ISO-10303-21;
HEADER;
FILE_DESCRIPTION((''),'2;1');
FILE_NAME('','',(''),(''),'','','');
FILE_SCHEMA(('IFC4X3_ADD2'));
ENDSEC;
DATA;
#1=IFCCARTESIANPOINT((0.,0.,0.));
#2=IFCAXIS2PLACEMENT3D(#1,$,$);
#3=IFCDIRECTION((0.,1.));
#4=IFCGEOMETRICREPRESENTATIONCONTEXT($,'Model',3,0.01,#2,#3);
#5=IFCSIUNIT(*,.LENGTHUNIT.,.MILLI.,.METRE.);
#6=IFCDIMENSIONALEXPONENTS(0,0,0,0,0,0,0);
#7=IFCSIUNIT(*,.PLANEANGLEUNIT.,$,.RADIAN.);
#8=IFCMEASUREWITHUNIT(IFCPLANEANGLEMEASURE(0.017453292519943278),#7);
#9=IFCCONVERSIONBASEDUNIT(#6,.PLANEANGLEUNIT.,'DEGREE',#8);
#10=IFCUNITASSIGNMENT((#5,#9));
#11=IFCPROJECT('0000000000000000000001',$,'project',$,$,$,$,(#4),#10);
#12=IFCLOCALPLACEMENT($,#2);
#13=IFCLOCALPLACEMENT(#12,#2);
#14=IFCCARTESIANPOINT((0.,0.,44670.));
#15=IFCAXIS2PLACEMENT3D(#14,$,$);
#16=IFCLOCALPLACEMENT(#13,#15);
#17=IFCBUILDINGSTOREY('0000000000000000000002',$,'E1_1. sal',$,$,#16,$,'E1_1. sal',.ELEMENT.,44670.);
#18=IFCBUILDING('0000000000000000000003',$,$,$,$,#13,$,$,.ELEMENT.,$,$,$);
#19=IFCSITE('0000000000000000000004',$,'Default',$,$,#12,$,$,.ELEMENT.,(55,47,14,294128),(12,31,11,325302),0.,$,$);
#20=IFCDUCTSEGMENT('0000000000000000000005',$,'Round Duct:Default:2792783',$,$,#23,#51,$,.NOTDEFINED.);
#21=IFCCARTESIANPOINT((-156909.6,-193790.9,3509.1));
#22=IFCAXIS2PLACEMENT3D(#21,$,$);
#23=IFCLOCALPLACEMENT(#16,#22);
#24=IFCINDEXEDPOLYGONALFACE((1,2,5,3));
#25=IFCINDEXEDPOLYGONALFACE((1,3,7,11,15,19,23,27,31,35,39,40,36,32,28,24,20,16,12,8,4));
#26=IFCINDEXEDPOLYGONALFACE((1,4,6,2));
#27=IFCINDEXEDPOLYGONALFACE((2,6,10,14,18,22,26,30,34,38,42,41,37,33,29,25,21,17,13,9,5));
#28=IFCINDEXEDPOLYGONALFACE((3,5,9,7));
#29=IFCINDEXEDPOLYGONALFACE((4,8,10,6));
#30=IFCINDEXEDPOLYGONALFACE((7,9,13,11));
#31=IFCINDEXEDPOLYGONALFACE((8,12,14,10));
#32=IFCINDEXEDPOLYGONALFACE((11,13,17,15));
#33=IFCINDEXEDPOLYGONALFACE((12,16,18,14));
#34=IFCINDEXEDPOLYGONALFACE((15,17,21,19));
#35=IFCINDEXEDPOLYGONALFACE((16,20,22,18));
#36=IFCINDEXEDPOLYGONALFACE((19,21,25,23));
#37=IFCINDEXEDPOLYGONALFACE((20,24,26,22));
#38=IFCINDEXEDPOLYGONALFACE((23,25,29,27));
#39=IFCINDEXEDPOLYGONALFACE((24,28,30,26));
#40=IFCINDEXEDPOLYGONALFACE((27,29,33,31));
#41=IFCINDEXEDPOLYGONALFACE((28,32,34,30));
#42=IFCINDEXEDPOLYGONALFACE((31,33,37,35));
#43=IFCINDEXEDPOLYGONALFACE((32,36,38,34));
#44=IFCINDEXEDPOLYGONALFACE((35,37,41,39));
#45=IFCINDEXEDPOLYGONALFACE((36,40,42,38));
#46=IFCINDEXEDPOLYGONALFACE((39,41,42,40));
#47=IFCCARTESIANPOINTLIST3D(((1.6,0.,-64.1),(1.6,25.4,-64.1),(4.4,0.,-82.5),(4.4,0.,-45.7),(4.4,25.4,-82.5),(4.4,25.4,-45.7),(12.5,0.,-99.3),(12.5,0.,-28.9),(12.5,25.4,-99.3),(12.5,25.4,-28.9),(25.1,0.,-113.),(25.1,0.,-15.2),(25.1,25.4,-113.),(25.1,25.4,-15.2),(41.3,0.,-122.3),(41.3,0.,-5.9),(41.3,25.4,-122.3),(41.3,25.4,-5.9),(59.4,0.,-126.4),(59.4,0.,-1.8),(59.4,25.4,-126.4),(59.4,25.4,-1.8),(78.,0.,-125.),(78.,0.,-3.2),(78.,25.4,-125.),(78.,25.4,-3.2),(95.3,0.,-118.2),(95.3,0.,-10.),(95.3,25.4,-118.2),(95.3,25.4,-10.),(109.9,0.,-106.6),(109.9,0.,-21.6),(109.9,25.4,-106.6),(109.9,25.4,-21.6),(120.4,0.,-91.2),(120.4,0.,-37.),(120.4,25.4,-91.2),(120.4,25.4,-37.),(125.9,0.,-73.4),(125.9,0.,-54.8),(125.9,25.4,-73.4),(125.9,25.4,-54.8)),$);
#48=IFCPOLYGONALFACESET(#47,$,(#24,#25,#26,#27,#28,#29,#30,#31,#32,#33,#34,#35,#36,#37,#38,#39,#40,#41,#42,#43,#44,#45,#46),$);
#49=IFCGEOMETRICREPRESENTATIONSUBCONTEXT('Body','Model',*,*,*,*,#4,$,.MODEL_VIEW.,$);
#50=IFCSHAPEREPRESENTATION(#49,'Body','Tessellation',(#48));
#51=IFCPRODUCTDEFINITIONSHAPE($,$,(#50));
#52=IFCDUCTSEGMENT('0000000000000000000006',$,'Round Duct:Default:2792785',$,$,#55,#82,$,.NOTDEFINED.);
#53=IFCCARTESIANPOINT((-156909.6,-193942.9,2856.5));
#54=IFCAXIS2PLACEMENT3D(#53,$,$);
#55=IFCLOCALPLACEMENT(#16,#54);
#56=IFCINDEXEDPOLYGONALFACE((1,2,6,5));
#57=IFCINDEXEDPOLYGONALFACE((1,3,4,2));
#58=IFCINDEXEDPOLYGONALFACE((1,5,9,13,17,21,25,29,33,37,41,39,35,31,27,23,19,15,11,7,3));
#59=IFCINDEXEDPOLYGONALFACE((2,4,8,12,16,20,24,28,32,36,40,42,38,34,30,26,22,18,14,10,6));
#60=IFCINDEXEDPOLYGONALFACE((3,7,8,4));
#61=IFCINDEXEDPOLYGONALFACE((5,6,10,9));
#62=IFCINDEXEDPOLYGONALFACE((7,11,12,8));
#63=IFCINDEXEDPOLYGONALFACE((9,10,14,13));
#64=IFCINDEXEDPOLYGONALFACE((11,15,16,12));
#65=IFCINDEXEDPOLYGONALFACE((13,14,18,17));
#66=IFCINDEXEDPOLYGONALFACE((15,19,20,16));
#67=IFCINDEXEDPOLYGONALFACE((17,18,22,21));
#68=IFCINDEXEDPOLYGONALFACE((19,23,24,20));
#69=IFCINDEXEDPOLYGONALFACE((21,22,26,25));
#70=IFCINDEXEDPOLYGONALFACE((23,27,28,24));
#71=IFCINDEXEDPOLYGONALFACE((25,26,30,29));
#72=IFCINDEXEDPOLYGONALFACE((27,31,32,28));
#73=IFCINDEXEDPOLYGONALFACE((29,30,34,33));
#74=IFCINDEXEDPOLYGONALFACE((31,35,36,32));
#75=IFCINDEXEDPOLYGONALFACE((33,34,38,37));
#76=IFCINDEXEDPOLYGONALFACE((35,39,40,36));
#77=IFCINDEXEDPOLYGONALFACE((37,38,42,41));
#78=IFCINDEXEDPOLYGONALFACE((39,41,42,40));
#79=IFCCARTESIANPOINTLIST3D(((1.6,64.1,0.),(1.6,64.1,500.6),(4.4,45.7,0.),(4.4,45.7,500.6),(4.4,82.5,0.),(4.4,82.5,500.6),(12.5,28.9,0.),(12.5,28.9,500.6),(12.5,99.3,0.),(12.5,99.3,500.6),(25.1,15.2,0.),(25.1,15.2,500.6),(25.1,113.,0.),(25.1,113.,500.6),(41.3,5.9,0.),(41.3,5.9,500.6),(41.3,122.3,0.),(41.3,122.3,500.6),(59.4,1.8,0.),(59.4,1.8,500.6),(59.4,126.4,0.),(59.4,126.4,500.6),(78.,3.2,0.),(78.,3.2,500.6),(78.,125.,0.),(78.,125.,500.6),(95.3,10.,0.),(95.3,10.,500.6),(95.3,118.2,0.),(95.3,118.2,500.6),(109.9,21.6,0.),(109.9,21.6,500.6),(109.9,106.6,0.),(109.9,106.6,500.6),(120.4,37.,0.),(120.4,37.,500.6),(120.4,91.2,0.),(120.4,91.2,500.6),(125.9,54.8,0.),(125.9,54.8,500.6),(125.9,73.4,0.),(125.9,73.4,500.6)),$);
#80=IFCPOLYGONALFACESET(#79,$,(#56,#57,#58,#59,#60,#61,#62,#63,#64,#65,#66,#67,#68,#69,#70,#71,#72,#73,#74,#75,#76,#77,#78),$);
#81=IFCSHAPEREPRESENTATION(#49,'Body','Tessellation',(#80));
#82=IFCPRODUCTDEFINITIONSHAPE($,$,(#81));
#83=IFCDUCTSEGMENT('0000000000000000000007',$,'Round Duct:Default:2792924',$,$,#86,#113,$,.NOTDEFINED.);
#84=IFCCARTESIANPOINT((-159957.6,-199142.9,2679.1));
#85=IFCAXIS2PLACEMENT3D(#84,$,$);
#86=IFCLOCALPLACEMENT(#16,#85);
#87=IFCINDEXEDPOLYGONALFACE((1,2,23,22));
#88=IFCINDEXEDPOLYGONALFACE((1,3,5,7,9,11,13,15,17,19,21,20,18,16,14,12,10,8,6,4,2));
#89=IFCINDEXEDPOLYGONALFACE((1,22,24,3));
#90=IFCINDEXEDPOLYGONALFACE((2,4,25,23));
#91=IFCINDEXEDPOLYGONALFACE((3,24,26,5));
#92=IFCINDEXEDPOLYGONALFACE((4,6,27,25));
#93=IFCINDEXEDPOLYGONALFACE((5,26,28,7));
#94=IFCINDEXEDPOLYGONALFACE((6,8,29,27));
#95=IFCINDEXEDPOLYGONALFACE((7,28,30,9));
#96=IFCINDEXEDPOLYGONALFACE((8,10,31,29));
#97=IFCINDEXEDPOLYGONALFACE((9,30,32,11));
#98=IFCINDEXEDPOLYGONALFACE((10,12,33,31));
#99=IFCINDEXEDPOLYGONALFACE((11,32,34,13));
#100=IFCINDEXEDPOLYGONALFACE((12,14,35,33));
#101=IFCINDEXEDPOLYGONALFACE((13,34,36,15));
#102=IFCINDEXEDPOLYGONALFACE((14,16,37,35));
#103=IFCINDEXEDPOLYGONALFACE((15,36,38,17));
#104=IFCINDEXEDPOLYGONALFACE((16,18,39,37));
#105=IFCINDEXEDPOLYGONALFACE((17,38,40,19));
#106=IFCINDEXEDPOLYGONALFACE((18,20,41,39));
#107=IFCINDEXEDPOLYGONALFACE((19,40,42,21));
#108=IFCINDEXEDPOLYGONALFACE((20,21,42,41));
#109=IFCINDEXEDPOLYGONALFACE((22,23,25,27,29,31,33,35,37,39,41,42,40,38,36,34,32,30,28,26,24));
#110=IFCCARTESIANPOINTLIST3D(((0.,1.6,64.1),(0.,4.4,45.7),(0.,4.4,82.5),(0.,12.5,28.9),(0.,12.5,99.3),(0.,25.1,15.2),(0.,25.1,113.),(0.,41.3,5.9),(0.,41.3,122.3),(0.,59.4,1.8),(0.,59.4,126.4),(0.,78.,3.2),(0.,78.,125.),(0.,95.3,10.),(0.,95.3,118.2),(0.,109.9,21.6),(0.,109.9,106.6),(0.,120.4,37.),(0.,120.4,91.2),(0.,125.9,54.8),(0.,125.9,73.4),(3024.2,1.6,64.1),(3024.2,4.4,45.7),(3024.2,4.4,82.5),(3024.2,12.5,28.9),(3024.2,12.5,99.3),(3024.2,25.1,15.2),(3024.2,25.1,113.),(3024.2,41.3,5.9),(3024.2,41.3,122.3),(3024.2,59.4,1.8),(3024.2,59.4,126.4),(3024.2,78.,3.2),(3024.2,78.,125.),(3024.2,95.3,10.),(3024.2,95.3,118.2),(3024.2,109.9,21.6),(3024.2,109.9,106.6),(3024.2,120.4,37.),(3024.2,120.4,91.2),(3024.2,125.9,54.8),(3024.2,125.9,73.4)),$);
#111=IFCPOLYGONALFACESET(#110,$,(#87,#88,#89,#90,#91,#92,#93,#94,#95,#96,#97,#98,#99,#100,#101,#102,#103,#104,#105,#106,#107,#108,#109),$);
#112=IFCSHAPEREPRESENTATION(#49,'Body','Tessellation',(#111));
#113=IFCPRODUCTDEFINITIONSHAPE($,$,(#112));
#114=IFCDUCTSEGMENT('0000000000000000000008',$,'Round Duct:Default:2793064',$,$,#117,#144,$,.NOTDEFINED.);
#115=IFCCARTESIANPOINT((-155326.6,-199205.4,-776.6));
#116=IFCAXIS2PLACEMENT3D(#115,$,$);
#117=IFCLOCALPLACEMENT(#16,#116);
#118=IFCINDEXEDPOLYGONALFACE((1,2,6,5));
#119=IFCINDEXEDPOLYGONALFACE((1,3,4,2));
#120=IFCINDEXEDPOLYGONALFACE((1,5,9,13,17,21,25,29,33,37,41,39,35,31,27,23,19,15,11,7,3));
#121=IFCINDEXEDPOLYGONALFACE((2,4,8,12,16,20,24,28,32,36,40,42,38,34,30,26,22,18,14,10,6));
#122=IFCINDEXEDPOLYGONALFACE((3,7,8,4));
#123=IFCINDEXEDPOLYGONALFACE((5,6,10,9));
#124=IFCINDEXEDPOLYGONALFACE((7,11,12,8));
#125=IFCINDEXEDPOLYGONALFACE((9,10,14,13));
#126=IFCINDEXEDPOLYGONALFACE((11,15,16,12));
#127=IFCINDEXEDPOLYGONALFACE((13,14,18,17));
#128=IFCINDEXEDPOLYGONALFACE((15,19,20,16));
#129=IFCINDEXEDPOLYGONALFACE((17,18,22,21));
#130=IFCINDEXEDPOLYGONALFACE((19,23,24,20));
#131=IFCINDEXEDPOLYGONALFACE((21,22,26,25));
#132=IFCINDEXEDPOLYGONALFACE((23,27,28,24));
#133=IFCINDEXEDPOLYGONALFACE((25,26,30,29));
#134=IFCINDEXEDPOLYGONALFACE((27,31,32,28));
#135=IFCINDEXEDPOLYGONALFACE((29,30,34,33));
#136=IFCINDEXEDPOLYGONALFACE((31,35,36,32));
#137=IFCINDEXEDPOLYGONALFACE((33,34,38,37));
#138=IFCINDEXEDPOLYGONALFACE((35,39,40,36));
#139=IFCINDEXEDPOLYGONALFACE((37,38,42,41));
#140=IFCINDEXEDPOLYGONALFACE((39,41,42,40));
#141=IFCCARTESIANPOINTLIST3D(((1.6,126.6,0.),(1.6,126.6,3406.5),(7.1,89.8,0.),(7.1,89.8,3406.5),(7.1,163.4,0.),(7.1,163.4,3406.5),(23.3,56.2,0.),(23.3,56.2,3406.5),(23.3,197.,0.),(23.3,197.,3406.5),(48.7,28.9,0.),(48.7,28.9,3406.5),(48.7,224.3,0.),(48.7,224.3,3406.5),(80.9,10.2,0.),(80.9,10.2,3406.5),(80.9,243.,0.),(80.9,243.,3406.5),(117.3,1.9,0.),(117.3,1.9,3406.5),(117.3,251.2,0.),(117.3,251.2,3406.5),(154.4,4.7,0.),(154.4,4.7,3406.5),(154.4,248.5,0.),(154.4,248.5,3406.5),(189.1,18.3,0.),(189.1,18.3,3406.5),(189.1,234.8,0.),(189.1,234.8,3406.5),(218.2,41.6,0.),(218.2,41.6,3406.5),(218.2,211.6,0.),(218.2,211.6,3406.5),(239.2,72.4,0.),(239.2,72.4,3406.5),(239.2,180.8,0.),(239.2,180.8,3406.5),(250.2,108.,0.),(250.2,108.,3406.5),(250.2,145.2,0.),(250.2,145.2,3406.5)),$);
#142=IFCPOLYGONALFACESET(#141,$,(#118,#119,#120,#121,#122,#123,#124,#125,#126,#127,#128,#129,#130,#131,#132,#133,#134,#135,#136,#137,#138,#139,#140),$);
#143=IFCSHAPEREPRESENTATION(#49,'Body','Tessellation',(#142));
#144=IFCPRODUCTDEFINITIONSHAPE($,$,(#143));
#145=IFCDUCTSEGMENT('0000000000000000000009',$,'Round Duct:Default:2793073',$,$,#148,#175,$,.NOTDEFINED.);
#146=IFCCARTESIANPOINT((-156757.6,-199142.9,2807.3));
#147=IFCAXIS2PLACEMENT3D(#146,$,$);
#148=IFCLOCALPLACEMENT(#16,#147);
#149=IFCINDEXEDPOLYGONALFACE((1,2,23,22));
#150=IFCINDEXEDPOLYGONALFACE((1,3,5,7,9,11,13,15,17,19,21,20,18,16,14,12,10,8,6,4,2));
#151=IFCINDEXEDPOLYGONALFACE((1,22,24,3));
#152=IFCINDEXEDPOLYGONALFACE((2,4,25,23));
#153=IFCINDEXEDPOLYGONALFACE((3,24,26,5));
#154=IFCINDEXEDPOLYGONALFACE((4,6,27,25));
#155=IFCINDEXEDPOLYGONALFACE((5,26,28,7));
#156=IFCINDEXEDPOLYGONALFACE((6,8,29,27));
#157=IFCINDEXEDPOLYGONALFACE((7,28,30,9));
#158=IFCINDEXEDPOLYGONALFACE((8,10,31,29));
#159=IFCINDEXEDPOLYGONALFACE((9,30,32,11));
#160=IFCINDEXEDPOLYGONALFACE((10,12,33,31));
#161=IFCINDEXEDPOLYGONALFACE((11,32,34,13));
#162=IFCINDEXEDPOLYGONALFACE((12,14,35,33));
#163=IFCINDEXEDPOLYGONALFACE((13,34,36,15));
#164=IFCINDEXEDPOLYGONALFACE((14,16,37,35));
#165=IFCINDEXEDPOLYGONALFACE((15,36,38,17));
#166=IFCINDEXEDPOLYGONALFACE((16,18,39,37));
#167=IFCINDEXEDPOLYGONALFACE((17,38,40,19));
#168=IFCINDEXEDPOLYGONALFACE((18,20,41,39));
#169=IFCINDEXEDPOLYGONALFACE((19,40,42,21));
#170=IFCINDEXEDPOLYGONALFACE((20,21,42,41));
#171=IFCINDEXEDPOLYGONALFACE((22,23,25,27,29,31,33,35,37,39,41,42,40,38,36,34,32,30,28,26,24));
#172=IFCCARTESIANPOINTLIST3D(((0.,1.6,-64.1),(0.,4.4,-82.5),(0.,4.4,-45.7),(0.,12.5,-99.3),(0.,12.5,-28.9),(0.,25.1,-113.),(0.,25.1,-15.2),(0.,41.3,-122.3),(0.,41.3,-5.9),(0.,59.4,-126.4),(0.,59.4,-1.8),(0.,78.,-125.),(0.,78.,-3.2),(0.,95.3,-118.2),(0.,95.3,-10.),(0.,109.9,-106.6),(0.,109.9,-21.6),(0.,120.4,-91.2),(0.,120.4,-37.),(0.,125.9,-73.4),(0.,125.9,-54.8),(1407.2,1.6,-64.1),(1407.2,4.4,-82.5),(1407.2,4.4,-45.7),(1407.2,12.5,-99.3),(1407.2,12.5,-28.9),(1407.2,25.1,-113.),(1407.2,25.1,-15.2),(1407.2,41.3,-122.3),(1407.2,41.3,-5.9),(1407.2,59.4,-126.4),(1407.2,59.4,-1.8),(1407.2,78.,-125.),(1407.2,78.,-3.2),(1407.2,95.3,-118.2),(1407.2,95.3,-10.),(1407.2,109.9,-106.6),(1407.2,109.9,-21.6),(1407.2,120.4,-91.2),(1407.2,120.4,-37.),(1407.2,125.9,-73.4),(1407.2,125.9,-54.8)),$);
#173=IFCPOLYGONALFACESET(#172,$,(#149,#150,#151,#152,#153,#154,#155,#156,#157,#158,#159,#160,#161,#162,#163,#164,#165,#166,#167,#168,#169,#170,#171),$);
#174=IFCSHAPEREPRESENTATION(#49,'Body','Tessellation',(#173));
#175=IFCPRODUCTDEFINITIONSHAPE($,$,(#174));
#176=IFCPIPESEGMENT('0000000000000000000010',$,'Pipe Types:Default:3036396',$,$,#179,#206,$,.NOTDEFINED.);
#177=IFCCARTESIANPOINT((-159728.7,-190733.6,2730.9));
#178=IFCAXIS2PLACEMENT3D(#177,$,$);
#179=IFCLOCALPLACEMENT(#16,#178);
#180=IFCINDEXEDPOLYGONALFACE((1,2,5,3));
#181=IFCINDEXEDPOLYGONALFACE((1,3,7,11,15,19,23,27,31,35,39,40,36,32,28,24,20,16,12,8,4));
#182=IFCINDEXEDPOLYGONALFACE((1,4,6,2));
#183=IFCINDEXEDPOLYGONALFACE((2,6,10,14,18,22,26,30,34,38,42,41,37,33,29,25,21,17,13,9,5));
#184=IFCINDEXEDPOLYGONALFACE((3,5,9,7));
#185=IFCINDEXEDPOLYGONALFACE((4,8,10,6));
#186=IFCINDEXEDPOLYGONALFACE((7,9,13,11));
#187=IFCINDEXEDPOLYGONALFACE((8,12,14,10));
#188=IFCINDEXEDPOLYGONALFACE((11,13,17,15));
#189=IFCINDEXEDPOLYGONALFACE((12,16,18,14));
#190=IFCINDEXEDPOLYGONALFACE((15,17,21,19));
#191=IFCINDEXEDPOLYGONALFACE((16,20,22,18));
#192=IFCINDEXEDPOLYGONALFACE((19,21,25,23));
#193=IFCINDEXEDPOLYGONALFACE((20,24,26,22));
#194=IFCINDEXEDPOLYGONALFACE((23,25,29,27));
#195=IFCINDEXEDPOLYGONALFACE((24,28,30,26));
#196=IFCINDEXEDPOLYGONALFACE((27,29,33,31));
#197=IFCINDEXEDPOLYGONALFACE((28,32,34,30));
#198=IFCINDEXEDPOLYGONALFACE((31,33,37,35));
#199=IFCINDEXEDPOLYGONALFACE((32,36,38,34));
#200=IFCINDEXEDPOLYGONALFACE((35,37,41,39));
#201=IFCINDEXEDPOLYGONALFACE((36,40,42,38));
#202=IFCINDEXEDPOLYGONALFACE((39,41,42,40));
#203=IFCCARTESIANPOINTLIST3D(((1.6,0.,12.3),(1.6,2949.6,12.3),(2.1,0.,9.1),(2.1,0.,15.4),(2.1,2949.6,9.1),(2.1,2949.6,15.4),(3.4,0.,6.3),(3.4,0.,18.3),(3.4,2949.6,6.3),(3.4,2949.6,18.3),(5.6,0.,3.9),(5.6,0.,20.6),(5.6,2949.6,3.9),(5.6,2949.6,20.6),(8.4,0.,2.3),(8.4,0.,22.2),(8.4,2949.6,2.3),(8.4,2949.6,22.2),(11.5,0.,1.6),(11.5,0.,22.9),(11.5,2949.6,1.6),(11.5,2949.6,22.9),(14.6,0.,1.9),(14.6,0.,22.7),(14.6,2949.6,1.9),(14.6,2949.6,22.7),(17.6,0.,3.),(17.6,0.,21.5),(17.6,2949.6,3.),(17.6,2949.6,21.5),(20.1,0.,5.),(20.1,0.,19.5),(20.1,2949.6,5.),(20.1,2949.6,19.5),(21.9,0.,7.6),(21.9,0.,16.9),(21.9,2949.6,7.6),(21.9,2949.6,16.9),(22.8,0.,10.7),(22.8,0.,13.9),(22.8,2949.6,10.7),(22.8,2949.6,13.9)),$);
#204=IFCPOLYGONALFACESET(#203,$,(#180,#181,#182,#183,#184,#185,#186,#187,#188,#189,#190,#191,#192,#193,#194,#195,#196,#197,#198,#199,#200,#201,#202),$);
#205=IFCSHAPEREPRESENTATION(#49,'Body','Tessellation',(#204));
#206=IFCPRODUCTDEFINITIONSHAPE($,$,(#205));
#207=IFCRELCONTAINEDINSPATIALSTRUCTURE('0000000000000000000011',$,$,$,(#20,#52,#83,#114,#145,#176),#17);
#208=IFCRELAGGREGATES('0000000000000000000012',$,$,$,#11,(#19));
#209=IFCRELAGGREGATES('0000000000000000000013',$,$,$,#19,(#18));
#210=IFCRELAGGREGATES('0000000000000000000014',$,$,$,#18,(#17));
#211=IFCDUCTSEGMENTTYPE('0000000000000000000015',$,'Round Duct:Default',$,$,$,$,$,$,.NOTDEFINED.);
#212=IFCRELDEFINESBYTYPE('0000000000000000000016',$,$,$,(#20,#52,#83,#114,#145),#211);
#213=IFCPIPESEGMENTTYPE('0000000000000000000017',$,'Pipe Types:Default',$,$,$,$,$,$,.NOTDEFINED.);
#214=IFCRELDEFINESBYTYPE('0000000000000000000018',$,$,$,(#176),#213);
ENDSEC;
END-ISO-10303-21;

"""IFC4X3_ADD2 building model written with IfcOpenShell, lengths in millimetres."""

from ifc_helpers import new_model, entity, si_unit, converted_unit, direction, frame, origin, origin_2d_with_axis, place, context, subcontext, project, spatial, circle, extrude, type_object, element, save


model = new_model("IFC4X3_ADD2")

# Units and contexts
model_context = context("Model", 3, precision=0.01, world=origin(), true_north=direction((0.0, 1.0)))
body_context = subcontext(model_context, "Body", "Model", "MODEL_VIEW")
ifc_project = project(units=[si_unit("LENGTHUNIT", "METRE", prefix="MILLI"), converted_unit("PLANEANGLEUNIT", "DEGREE", entity("IfcPlaneAngleMeasure", 0.017453292519943278), si_unit("PLANEANGLEUNIT", "RADIAN"), dimensions=[0, 0, 0, 0, 0, 0, 0])], contexts=[model_context])

# Site, building, storey
site_placement = place(None, origin())
site = spatial("IfcSite", under=ifc_project, at=site_placement, Name="Default", CompositionType="ELEMENT", RefLatitude=(55, 47, 14, 294128), RefLongitude=(12, 31, 11, 325302), RefElevation=0.0)
building_placement = place(site_placement, origin())
building = spatial("IfcBuilding", under=site, at=building_placement, CompositionType="ELEMENT")
storey_placement = place(building_placement, frame((0.0, 0.0, 44670.0)))
storey = spatial("IfcBuildingStorey", under=building, at=storey_placement, Name="E1_1. sal", LongName="E1_1. sal", CompositionType="ELEMENT", Elevation=44670.0)

# Duct segments
duct_segment_type = type_object("IfcDuctSegmentType", Name="Round Duct:Default", PredefinedType="NOTDEFINED")
duct_segment_1_placement = place(storey_placement, frame((-156909.6, -193790.9, 3509.1)))
element("IfcDuctSegment", 1, at=duct_segment_1_placement, inside=storey, type_object=duct_segment_type, Name="Round Duct:Default:2792783", PredefinedType="NOTDEFINED", context=body_context, shape_type="SweptSolid", body=[
    extrude(circle(Radius=62.5, at=origin_2d_with_axis()), frame((64.1, 0.0, -64.1), z_axis=(0.0, 1.0, 0.0), x_axis=(-1.0, 0.0, 0.0)), (0.0, 0.0, 1.0), 25.4),
])
duct_segment_2_placement = place(storey_placement, frame((-156909.6, -193942.9, 2856.5)))
element("IfcDuctSegment", 2, at=duct_segment_2_placement, inside=storey, type_object=duct_segment_type, Name="Round Duct:Default:2792785", PredefinedType="NOTDEFINED", context=body_context, shape_type="SweptSolid", body=[
    extrude(circle(Radius=62.5, at=origin_2d_with_axis()), frame((64.1, 64.1, 0.0), z_axis=(0.0, 0.0, 1.0), x_axis=(-1.0, 0.0, 0.0)), (0.0, 0.0, 1.0), 500.6),
])
duct_segment_3_placement = place(storey_placement, frame((-159957.6, -199142.9, 2679.1)))
element("IfcDuctSegment", 3, at=duct_segment_3_placement, inside=storey, type_object=duct_segment_type, Name="Round Duct:Default:2792924", PredefinedType="NOTDEFINED", context=body_context, shape_type="SweptSolid", body=[
    extrude(circle(Radius=62.5, at=origin_2d_with_axis()), frame((0.0, 64.1, 64.1), z_axis=(1.0, 0.0, 0.0), x_axis=(0.0, -1.0, 0.0)), (0.0, 0.0, 1.0), 3024.2),
])
duct_segment_4_placement = place(storey_placement, frame((-155326.6, -199205.4, -776.6)))
element("IfcDuctSegment", 4, at=duct_segment_4_placement, inside=storey, type_object=duct_segment_type, Name="Round Duct:Default:2793064", PredefinedType="NOTDEFINED", context=body_context, shape_type="SweptSolid", body=[
    extrude(circle(Radius=125.0, at=origin_2d_with_axis()), frame((126.6, 126.6, 0.0), z_axis=(0.0, 0.0, 1.0), x_axis=(-1.0, 0.0, 0.0)), (0.0, 0.0, 1.0), 3406.5),
])
duct_segment_5_placement = place(storey_placement, frame((-156757.6, -199142.9, 2807.3)))
element("IfcDuctSegment", 5, at=duct_segment_5_placement, inside=storey, type_object=duct_segment_type, Name="Round Duct:Default:2793073", PredefinedType="NOTDEFINED", context=body_context, shape_type="SweptSolid", body=[
    extrude(circle(Radius=62.5, at=origin_2d_with_axis()), frame((0.0, 64.1, -64.1), z_axis=(1.0, 0.0, 0.0), x_axis=(0.0, -1.0, 0.0)), (0.0, 0.0, 1.0), 1407.2),
])

# Pipe segment
pipe_segment_type = type_object("IfcPipeSegmentType", Name="Pipe Types:Default", PredefinedType="NOTDEFINED")
pipe_segment_1_placement = place(storey_placement, frame((-159728.7, -190733.6, 2730.9)))
element("IfcPipeSegment", 6, at=pipe_segment_1_placement, inside=storey, type_object=pipe_segment_type, Name="Pipe Types:Default:3036396", PredefinedType="NOTDEFINED", context=body_context, shape_type="SweptSolid", body=[
    extrude(circle(Radius=10.7, at=origin_2d_with_axis()), frame((12.3, 0.0, 12.3), z_axis=(0.0, 1.0, 0.0), x_axis=(-1.0, 0.0, 0.0)), (0.0, 0.0, 1.0), 2949.6),
])

save(model, "model.ifc")
